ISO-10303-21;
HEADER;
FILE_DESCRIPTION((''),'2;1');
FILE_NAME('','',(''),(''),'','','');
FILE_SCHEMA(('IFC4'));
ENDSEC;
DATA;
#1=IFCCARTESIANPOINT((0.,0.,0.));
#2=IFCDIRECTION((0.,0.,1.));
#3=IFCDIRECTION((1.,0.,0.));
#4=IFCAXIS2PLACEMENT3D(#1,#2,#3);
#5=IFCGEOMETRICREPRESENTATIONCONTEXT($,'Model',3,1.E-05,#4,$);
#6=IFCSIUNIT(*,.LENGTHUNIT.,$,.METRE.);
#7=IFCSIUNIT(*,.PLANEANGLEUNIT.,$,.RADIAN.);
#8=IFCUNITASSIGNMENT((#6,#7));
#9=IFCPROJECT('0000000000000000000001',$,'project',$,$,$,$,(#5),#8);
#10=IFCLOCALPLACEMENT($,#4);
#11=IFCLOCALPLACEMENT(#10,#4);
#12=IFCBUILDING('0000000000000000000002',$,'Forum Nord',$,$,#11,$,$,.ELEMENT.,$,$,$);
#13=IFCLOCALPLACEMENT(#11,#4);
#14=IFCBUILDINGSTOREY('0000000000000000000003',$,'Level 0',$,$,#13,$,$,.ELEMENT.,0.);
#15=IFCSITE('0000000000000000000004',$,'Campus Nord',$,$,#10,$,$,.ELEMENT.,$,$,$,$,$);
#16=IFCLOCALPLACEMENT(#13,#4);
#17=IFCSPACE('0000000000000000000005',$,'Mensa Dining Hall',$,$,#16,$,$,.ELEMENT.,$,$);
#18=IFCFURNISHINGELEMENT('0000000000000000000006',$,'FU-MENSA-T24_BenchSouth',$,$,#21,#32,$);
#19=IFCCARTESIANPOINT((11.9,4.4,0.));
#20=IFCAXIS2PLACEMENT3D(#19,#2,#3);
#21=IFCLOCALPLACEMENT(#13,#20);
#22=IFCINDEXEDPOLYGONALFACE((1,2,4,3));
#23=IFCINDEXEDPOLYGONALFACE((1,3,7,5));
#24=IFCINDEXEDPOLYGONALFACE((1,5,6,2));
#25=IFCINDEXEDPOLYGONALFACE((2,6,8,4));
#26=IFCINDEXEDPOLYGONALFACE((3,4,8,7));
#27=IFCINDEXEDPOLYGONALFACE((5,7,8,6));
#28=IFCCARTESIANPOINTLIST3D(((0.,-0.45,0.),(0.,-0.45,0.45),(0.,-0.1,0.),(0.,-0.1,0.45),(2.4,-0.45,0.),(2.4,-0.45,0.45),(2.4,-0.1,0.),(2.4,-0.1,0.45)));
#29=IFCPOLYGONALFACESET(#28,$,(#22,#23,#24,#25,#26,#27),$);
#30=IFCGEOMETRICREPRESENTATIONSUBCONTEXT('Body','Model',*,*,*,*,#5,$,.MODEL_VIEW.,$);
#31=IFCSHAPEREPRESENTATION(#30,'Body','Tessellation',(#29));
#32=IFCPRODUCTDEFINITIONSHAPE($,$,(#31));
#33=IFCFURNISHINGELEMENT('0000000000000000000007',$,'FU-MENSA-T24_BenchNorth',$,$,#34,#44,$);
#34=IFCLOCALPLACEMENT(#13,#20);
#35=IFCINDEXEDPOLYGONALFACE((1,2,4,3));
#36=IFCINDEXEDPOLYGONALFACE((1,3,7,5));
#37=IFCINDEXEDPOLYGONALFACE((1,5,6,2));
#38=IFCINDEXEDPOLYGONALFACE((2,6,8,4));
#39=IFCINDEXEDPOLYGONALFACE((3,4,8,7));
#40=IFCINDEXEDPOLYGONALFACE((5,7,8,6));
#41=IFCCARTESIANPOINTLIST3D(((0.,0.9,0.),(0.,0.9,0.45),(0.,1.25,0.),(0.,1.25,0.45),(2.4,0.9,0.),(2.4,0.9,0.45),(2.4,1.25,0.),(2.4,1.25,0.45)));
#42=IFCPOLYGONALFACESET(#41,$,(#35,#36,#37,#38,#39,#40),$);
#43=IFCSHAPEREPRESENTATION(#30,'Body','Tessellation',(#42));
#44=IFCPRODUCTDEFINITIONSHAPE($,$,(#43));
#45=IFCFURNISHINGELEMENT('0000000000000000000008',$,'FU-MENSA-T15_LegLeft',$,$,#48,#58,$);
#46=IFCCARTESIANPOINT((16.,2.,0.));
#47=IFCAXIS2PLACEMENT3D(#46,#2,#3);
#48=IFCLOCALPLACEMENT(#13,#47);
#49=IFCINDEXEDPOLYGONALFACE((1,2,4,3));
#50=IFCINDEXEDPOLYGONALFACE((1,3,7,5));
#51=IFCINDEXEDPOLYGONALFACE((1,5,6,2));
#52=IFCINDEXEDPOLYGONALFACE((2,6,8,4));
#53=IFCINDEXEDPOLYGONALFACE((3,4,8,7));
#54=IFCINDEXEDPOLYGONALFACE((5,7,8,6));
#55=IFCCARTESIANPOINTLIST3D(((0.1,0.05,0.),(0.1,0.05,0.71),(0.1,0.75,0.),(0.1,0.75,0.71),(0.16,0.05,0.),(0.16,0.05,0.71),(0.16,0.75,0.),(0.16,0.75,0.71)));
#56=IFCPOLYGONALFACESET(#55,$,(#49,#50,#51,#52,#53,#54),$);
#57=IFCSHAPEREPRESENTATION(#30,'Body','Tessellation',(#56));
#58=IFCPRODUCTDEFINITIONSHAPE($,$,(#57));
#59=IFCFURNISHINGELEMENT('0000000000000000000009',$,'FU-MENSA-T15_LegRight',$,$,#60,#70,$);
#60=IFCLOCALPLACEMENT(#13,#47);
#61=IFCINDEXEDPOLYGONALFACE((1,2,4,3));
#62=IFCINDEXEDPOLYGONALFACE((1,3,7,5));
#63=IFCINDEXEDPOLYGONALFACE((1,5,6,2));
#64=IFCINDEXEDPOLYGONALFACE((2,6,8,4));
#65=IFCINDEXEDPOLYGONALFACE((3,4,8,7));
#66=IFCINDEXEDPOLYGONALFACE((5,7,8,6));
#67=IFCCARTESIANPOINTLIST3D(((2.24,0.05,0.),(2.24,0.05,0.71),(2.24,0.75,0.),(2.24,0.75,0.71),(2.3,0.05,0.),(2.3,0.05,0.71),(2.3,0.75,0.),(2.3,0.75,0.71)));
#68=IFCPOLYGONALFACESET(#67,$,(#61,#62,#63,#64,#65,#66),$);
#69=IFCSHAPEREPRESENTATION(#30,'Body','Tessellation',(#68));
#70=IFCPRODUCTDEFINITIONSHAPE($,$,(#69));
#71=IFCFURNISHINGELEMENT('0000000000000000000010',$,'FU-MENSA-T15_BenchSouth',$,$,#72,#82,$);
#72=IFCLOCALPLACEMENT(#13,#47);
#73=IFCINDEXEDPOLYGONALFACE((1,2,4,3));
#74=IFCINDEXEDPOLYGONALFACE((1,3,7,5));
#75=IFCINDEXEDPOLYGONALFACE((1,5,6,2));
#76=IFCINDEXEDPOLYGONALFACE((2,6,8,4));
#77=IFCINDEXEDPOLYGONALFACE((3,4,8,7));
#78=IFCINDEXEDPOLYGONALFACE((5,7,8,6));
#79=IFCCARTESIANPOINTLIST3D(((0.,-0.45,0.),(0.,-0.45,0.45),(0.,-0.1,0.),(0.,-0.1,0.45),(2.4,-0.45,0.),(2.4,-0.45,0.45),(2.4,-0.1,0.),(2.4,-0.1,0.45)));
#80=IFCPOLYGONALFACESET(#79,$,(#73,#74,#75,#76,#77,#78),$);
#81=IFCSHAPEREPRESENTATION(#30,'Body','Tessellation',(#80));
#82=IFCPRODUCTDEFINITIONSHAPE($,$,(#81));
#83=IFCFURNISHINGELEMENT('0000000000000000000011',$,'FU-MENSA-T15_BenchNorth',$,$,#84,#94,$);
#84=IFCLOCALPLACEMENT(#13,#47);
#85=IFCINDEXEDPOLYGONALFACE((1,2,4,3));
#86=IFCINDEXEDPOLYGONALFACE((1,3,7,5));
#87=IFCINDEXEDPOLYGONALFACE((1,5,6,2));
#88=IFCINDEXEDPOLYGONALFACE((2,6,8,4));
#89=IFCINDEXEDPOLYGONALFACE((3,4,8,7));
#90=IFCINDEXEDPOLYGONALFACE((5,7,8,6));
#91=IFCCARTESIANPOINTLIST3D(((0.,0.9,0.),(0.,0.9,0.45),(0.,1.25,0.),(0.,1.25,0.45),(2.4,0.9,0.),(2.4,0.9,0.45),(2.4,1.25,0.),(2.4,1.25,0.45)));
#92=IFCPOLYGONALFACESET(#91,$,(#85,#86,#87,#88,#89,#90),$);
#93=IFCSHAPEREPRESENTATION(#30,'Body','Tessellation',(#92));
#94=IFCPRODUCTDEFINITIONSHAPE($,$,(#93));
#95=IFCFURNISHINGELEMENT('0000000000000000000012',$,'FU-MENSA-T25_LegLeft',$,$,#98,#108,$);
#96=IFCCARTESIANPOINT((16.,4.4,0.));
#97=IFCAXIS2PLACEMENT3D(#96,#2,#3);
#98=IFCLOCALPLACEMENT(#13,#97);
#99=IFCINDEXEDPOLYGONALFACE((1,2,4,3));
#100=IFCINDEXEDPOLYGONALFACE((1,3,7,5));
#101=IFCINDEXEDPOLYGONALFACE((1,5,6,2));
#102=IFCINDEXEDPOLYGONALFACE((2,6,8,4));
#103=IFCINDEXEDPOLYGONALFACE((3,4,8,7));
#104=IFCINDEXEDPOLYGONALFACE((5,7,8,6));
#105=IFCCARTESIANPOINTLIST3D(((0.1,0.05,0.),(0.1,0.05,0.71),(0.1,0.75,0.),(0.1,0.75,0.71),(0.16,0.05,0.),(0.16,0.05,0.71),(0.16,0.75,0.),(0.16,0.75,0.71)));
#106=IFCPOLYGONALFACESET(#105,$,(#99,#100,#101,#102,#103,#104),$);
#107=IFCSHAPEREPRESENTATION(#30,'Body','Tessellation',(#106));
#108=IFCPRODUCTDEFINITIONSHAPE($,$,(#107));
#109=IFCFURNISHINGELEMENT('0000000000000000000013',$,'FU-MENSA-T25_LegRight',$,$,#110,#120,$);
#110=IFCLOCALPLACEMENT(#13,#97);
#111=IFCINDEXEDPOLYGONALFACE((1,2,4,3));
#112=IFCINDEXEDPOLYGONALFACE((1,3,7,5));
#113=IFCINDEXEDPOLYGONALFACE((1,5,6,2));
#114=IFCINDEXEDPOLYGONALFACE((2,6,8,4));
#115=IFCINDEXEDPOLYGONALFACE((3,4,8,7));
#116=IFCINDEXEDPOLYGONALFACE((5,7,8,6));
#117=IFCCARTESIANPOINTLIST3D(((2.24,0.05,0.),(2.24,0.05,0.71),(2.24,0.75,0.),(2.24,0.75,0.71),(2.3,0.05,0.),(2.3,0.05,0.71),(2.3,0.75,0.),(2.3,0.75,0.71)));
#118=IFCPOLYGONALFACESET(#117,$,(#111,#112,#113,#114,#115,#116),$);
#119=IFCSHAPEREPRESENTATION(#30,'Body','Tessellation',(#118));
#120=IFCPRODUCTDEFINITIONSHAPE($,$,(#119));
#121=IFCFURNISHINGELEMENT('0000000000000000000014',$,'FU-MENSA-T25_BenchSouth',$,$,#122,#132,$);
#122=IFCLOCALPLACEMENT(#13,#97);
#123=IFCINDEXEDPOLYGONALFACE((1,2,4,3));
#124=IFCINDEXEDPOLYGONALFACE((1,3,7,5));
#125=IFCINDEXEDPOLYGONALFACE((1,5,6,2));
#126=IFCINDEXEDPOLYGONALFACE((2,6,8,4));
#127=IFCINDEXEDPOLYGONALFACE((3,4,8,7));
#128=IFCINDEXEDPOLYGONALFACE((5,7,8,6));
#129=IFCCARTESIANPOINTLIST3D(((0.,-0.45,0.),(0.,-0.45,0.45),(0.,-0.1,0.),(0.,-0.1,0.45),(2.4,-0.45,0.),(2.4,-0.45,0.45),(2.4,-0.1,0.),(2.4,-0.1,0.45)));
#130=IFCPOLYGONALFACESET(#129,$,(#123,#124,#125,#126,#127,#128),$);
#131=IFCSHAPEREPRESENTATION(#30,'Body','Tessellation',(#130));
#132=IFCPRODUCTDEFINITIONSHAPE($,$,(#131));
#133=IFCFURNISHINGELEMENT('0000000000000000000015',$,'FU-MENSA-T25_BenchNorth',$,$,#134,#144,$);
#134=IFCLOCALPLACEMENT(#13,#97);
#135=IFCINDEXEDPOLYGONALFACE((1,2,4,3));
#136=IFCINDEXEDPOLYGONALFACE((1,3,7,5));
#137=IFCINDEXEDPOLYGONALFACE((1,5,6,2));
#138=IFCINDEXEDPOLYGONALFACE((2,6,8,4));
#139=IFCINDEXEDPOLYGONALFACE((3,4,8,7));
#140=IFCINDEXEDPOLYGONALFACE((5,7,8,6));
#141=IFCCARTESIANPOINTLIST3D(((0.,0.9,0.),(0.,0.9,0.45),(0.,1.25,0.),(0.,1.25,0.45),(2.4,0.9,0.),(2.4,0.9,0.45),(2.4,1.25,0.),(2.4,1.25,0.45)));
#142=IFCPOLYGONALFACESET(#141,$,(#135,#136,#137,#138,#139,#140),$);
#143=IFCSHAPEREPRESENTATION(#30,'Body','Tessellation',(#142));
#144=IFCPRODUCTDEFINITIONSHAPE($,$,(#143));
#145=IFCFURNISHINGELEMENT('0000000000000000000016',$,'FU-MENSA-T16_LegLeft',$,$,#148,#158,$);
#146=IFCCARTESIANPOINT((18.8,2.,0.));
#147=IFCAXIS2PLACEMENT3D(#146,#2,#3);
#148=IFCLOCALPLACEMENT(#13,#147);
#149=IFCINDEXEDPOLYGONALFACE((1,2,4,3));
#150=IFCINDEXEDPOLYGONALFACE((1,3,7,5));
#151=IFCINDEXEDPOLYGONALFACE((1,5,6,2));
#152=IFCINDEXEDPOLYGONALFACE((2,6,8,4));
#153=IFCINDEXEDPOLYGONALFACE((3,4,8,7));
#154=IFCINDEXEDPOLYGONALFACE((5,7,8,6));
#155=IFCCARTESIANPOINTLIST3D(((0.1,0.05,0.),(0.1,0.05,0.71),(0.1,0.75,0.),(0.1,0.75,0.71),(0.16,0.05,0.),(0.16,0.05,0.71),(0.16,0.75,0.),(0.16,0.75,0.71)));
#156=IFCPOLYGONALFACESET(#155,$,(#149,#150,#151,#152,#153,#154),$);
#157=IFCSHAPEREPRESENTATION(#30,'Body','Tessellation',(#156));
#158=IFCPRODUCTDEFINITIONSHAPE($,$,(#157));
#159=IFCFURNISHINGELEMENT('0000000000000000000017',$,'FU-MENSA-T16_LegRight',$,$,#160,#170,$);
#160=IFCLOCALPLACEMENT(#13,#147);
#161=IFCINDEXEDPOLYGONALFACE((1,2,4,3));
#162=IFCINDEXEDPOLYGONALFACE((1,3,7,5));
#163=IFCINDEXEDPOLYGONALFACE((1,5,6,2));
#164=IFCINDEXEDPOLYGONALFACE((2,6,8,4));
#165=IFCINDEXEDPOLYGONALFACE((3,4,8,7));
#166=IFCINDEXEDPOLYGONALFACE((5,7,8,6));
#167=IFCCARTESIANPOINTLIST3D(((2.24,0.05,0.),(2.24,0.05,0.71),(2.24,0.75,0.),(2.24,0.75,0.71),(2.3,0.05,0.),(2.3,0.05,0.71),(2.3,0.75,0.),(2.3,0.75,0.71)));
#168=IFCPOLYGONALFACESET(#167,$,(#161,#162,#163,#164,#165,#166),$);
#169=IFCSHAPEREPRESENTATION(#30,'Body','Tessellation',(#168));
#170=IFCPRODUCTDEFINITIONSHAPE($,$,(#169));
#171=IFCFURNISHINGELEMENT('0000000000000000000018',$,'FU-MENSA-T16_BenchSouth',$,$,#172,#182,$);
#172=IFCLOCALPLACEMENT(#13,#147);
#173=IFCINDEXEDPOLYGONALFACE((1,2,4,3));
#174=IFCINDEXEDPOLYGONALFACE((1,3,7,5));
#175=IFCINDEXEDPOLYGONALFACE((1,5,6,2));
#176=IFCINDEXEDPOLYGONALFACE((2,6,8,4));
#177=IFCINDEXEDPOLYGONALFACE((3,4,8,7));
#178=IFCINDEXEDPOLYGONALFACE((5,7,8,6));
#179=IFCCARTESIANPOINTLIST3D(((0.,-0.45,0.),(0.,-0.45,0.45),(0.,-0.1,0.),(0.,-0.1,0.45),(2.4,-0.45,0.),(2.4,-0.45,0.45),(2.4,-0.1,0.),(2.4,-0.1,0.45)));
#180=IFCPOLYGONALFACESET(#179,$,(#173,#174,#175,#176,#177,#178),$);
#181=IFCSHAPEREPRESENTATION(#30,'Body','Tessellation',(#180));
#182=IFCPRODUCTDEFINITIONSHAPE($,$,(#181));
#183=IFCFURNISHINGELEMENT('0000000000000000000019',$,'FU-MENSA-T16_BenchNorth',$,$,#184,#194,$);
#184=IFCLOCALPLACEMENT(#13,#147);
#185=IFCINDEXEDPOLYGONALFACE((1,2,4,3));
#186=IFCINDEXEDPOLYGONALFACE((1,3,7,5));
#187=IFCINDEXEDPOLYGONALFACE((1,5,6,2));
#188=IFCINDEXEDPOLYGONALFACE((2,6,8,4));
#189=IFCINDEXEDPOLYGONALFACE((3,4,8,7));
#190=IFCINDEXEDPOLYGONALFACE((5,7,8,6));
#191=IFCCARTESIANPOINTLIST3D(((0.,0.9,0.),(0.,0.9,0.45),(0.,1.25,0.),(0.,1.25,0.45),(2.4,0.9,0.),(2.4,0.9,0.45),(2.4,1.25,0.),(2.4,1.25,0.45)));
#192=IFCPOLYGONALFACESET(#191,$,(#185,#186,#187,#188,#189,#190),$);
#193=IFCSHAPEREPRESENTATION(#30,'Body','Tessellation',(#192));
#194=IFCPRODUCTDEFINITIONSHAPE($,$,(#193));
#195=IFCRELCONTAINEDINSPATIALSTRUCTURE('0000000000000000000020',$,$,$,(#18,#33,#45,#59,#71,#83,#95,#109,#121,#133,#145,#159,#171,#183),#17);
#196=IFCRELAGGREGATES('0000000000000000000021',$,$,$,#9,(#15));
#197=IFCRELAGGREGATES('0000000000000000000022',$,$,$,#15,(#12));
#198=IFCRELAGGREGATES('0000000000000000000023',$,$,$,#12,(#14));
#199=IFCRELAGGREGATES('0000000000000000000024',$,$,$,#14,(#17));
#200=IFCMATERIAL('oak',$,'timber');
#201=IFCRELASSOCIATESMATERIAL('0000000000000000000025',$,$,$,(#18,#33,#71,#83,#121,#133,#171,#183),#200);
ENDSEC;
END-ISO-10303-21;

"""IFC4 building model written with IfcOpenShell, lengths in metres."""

from ifc_helpers import new_model, si_unit, frame, frame_2d, origin_with_axes, place, context, subcontext, project, spatial, rectangle, extrude, material, element, save


model = new_model("IFC4")

# Units and contexts
model_context = context("Model", 3, precision=1e-05, world=origin_with_axes())
body_context = subcontext(model_context, "Body", "Model", "MODEL_VIEW")
ifc_project = project(units=[si_unit("LENGTHUNIT", "METRE"), si_unit("PLANEANGLEUNIT", "RADIAN")], contexts=[model_context])

# Site, building, storey
site_placement = place(None, origin_with_axes())
site = spatial("IfcSite", under=ifc_project, at=site_placement, Name="Campus Nord", CompositionType="ELEMENT")
building_placement = place(site_placement, origin_with_axes())
building = spatial("IfcBuilding", under=site, at=building_placement, Name="Forum Nord", CompositionType="ELEMENT")
storey_placement = place(building_placement, origin_with_axes())
storey = spatial("IfcBuildingStorey", under=building, at=storey_placement, Name="Level 0", CompositionType="ELEMENT", Elevation=0.0)

# Shared definitions
space_placement = place(storey_placement, origin_with_axes())
space = spatial("IfcSpace", under=storey, at=space_placement, Name="Mensa Dining Hall", CompositionType="ELEMENT")

# Furnishing elements
ifc_material_1 = material(Name="oak", Category="timber")
furnishing_1_placement = place(storey_placement, frame((11.9, 4.4, 0.0), z_axis=(0.0, 0.0, 1.0), x_axis=(1.0, 0.0, 0.0)))
element("IfcFurnishingElement", 1, at=furnishing_1_placement, inside=space, material=ifc_material_1, Name="FU-MENSA-T24_BenchSouth", context=body_context, shape_type="SweptSolid", body=[
    extrude(rectangle(XDim=2.4, YDim=0.35, at=frame_2d((1.2, -0.275), x_axis=(1.0, 0.0))), origin_with_axes(), (0.0, 0.0, 1.0), 0.45),
])
furnishing_2_placement = place(storey_placement, frame((11.9, 4.4, 0.0), z_axis=(0.0, 0.0, 1.0), x_axis=(1.0, 0.0, 0.0)))
element("IfcFurnishingElement", 2, at=furnishing_2_placement, inside=space, material=ifc_material_1, Name="FU-MENSA-T24_BenchNorth", context=body_context, shape_type="SweptSolid", body=[
    extrude(rectangle(XDim=2.4, YDim=0.35, at=frame_2d((1.2, 1.075), x_axis=(1.0, 0.0))), origin_with_axes(), (0.0, 0.0, 1.0), 0.45),
])
furnishing_3_placement = place(storey_placement, frame((16.0, 2.0, 0.0), z_axis=(0.0, 0.0, 1.0), x_axis=(1.0, 0.0, 0.0)))
element("IfcFurnishingElement", 3, at=furnishing_3_placement, inside=space, Name="FU-MENSA-T15_LegLeft", context=body_context, shape_type="SweptSolid", body=[
    extrude(rectangle(XDim=0.06, YDim=0.7, at=frame_2d((0.13, 0.4), x_axis=(1.0, 0.0))), origin_with_axes(), (0.0, 0.0, 1.0), 0.71),
])
furnishing_4_placement = place(storey_placement, frame((16.0, 2.0, 0.0), z_axis=(0.0, 0.0, 1.0), x_axis=(1.0, 0.0, 0.0)))
element("IfcFurnishingElement", 4, at=furnishing_4_placement, inside=space, Name="FU-MENSA-T15_LegRight", context=body_context, shape_type="SweptSolid", body=[
    extrude(rectangle(XDim=0.06, YDim=0.7, at=frame_2d((2.27, 0.4), x_axis=(1.0, 0.0))), origin_with_axes(), (0.0, 0.0, 1.0), 0.71),
])
furnishing_5_placement = place(storey_placement, frame((16.0, 2.0, 0.0), z_axis=(0.0, 0.0, 1.0), x_axis=(1.0, 0.0, 0.0)))
element("IfcFurnishingElement", 5, at=furnishing_5_placement, inside=space, material=ifc_material_1, Name="FU-MENSA-T15_BenchSouth", context=body_context, shape_type="SweptSolid", body=[
    extrude(rectangle(XDim=2.4, YDim=0.35, at=frame_2d((1.2, -0.275), x_axis=(1.0, 0.0))), origin_with_axes(), (0.0, 0.0, 1.0), 0.45),
])
furnishing_6_placement = place(storey_placement, frame((16.0, 2.0, 0.0), z_axis=(0.0, 0.0, 1.0), x_axis=(1.0, 0.0, 0.0)))
element("IfcFurnishingElement", 6, at=furnishing_6_placement, inside=space, material=ifc_material_1, Name="FU-MENSA-T15_BenchNorth", context=body_context, shape_type="SweptSolid", body=[
    extrude(rectangle(XDim=2.4, YDim=0.35, at=frame_2d((1.2, 1.075), x_axis=(1.0, 0.0))), origin_with_axes(), (0.0, 0.0, 1.0), 0.45),
])
furnishing_7_placement = place(storey_placement, frame((16.0, 4.4, 0.0), z_axis=(0.0, 0.0, 1.0), x_axis=(1.0, 0.0, 0.0)))
element("IfcFurnishingElement", 7, at=furnishing_7_placement, inside=space, Name="FU-MENSA-T25_LegLeft", context=body_context, shape_type="SweptSolid", body=[
    extrude(rectangle(XDim=0.06, YDim=0.7, at=frame_2d((0.13, 0.4), x_axis=(1.0, 0.0))), origin_with_axes(), (0.0, 0.0, 1.0), 0.71),
])
furnishing_8_placement = place(storey_placement, frame((16.0, 4.4, 0.0), z_axis=(0.0, 0.0, 1.0), x_axis=(1.0, 0.0, 0.0)))
element("IfcFurnishingElement", 8, at=furnishing_8_placement, inside=space, Name="FU-MENSA-T25_LegRight", context=body_context, shape_type="SweptSolid", body=[
    extrude(rectangle(XDim=0.06, YDim=0.7, at=frame_2d((2.27, 0.4), x_axis=(1.0, 0.0))), origin_with_axes(), (0.0, 0.0, 1.0), 0.71),
])
furnishing_9_placement = place(storey_placement, frame((16.0, 4.4, 0.0), z_axis=(0.0, 0.0, 1.0), x_axis=(1.0, 0.0, 0.0)))
element("IfcFurnishingElement", 9, at=furnishing_9_placement, inside=space, material=ifc_material_1, Name="FU-MENSA-T25_BenchSouth", context=body_context, shape_type="SweptSolid", body=[
    extrude(rectangle(XDim=2.4, YDim=0.35, at=frame_2d((1.2, -0.275), x_axis=(1.0, 0.0))), origin_with_axes(), (0.0, 0.0, 1.0), 0.45),
])
furnishing_10_placement = place(storey_placement, frame((16.0, 4.4, 0.0), z_axis=(0.0, 0.0, 1.0), x_axis=(1.0, 0.0, 0.0)))
element("IfcFurnishingElement", 10, at=furnishing_10_placement, inside=space, material=ifc_material_1, Name="FU-MENSA-T25_BenchNorth", context=body_context, shape_type="SweptSolid", body=[
    extrude(rectangle(XDim=2.4, YDim=0.35, at=frame_2d((1.2, 1.075), x_axis=(1.0, 0.0))), origin_with_axes(), (0.0, 0.0, 1.0), 0.45),
])
furnishing_11_placement = place(storey_placement, frame((18.8, 2.0, 0.0), z_axis=(0.0, 0.0, 1.0), x_axis=(1.0, 0.0, 0.0)))
element("IfcFurnishingElement", 11, at=furnishing_11_placement, inside=space, Name="FU-MENSA-T16_LegLeft", context=body_context, shape_type="SweptSolid", body=[
    extrude(rectangle(XDim=0.06, YDim=0.7, at=frame_2d((0.13, 0.4), x_axis=(1.0, 0.0))), origin_with_axes(), (0.0, 0.0, 1.0), 0.71),
])
furnishing_12_placement = place(storey_placement, frame((18.8, 2.0, 0.0), z_axis=(0.0, 0.0, 1.0), x_axis=(1.0, 0.0, 0.0)))
element("IfcFurnishingElement", 12, at=furnishing_12_placement, inside=space, Name="FU-MENSA-T16_LegRight", context=body_context, shape_type="SweptSolid", body=[
    extrude(rectangle(XDim=0.06, YDim=0.7, at=frame_2d((2.27, 0.4), x_axis=(1.0, 0.0))), origin_with_axes(), (0.0, 0.0, 1.0), 0.71),
])
furnishing_13_placement = place(storey_placement, frame((18.8, 2.0, 0.0), z_axis=(0.0, 0.0, 1.0), x_axis=(1.0, 0.0, 0.0)))
element("IfcFurnishingElement", 13, at=furnishing_13_placement, inside=space, material=ifc_material_1, Name="FU-MENSA-T16_BenchSouth", context=body_context, shape_type="SweptSolid", body=[
    extrude(rectangle(XDim=2.4, YDim=0.35, at=frame_2d((1.2, -0.275), x_axis=(1.0, 0.0))), origin_with_axes(), (0.0, 0.0, 1.0), 0.45),
])
furnishing_14_placement = place(storey_placement, frame((18.8, 2.0, 0.0), z_axis=(0.0, 0.0, 1.0), x_axis=(1.0, 0.0, 0.0)))
element("IfcFurnishingElement", 14, at=furnishing_14_placement, inside=space, material=ifc_material_1, Name="FU-MENSA-T16_BenchNorth", context=body_context, shape_type="SweptSolid", body=[
    extrude(rectangle(XDim=2.4, YDim=0.35, at=frame_2d((1.2, 1.075), x_axis=(1.0, 0.0))), origin_with_axes(), (0.0, 0.0, 1.0), 0.45),
])

save(model, "model.ifc")
